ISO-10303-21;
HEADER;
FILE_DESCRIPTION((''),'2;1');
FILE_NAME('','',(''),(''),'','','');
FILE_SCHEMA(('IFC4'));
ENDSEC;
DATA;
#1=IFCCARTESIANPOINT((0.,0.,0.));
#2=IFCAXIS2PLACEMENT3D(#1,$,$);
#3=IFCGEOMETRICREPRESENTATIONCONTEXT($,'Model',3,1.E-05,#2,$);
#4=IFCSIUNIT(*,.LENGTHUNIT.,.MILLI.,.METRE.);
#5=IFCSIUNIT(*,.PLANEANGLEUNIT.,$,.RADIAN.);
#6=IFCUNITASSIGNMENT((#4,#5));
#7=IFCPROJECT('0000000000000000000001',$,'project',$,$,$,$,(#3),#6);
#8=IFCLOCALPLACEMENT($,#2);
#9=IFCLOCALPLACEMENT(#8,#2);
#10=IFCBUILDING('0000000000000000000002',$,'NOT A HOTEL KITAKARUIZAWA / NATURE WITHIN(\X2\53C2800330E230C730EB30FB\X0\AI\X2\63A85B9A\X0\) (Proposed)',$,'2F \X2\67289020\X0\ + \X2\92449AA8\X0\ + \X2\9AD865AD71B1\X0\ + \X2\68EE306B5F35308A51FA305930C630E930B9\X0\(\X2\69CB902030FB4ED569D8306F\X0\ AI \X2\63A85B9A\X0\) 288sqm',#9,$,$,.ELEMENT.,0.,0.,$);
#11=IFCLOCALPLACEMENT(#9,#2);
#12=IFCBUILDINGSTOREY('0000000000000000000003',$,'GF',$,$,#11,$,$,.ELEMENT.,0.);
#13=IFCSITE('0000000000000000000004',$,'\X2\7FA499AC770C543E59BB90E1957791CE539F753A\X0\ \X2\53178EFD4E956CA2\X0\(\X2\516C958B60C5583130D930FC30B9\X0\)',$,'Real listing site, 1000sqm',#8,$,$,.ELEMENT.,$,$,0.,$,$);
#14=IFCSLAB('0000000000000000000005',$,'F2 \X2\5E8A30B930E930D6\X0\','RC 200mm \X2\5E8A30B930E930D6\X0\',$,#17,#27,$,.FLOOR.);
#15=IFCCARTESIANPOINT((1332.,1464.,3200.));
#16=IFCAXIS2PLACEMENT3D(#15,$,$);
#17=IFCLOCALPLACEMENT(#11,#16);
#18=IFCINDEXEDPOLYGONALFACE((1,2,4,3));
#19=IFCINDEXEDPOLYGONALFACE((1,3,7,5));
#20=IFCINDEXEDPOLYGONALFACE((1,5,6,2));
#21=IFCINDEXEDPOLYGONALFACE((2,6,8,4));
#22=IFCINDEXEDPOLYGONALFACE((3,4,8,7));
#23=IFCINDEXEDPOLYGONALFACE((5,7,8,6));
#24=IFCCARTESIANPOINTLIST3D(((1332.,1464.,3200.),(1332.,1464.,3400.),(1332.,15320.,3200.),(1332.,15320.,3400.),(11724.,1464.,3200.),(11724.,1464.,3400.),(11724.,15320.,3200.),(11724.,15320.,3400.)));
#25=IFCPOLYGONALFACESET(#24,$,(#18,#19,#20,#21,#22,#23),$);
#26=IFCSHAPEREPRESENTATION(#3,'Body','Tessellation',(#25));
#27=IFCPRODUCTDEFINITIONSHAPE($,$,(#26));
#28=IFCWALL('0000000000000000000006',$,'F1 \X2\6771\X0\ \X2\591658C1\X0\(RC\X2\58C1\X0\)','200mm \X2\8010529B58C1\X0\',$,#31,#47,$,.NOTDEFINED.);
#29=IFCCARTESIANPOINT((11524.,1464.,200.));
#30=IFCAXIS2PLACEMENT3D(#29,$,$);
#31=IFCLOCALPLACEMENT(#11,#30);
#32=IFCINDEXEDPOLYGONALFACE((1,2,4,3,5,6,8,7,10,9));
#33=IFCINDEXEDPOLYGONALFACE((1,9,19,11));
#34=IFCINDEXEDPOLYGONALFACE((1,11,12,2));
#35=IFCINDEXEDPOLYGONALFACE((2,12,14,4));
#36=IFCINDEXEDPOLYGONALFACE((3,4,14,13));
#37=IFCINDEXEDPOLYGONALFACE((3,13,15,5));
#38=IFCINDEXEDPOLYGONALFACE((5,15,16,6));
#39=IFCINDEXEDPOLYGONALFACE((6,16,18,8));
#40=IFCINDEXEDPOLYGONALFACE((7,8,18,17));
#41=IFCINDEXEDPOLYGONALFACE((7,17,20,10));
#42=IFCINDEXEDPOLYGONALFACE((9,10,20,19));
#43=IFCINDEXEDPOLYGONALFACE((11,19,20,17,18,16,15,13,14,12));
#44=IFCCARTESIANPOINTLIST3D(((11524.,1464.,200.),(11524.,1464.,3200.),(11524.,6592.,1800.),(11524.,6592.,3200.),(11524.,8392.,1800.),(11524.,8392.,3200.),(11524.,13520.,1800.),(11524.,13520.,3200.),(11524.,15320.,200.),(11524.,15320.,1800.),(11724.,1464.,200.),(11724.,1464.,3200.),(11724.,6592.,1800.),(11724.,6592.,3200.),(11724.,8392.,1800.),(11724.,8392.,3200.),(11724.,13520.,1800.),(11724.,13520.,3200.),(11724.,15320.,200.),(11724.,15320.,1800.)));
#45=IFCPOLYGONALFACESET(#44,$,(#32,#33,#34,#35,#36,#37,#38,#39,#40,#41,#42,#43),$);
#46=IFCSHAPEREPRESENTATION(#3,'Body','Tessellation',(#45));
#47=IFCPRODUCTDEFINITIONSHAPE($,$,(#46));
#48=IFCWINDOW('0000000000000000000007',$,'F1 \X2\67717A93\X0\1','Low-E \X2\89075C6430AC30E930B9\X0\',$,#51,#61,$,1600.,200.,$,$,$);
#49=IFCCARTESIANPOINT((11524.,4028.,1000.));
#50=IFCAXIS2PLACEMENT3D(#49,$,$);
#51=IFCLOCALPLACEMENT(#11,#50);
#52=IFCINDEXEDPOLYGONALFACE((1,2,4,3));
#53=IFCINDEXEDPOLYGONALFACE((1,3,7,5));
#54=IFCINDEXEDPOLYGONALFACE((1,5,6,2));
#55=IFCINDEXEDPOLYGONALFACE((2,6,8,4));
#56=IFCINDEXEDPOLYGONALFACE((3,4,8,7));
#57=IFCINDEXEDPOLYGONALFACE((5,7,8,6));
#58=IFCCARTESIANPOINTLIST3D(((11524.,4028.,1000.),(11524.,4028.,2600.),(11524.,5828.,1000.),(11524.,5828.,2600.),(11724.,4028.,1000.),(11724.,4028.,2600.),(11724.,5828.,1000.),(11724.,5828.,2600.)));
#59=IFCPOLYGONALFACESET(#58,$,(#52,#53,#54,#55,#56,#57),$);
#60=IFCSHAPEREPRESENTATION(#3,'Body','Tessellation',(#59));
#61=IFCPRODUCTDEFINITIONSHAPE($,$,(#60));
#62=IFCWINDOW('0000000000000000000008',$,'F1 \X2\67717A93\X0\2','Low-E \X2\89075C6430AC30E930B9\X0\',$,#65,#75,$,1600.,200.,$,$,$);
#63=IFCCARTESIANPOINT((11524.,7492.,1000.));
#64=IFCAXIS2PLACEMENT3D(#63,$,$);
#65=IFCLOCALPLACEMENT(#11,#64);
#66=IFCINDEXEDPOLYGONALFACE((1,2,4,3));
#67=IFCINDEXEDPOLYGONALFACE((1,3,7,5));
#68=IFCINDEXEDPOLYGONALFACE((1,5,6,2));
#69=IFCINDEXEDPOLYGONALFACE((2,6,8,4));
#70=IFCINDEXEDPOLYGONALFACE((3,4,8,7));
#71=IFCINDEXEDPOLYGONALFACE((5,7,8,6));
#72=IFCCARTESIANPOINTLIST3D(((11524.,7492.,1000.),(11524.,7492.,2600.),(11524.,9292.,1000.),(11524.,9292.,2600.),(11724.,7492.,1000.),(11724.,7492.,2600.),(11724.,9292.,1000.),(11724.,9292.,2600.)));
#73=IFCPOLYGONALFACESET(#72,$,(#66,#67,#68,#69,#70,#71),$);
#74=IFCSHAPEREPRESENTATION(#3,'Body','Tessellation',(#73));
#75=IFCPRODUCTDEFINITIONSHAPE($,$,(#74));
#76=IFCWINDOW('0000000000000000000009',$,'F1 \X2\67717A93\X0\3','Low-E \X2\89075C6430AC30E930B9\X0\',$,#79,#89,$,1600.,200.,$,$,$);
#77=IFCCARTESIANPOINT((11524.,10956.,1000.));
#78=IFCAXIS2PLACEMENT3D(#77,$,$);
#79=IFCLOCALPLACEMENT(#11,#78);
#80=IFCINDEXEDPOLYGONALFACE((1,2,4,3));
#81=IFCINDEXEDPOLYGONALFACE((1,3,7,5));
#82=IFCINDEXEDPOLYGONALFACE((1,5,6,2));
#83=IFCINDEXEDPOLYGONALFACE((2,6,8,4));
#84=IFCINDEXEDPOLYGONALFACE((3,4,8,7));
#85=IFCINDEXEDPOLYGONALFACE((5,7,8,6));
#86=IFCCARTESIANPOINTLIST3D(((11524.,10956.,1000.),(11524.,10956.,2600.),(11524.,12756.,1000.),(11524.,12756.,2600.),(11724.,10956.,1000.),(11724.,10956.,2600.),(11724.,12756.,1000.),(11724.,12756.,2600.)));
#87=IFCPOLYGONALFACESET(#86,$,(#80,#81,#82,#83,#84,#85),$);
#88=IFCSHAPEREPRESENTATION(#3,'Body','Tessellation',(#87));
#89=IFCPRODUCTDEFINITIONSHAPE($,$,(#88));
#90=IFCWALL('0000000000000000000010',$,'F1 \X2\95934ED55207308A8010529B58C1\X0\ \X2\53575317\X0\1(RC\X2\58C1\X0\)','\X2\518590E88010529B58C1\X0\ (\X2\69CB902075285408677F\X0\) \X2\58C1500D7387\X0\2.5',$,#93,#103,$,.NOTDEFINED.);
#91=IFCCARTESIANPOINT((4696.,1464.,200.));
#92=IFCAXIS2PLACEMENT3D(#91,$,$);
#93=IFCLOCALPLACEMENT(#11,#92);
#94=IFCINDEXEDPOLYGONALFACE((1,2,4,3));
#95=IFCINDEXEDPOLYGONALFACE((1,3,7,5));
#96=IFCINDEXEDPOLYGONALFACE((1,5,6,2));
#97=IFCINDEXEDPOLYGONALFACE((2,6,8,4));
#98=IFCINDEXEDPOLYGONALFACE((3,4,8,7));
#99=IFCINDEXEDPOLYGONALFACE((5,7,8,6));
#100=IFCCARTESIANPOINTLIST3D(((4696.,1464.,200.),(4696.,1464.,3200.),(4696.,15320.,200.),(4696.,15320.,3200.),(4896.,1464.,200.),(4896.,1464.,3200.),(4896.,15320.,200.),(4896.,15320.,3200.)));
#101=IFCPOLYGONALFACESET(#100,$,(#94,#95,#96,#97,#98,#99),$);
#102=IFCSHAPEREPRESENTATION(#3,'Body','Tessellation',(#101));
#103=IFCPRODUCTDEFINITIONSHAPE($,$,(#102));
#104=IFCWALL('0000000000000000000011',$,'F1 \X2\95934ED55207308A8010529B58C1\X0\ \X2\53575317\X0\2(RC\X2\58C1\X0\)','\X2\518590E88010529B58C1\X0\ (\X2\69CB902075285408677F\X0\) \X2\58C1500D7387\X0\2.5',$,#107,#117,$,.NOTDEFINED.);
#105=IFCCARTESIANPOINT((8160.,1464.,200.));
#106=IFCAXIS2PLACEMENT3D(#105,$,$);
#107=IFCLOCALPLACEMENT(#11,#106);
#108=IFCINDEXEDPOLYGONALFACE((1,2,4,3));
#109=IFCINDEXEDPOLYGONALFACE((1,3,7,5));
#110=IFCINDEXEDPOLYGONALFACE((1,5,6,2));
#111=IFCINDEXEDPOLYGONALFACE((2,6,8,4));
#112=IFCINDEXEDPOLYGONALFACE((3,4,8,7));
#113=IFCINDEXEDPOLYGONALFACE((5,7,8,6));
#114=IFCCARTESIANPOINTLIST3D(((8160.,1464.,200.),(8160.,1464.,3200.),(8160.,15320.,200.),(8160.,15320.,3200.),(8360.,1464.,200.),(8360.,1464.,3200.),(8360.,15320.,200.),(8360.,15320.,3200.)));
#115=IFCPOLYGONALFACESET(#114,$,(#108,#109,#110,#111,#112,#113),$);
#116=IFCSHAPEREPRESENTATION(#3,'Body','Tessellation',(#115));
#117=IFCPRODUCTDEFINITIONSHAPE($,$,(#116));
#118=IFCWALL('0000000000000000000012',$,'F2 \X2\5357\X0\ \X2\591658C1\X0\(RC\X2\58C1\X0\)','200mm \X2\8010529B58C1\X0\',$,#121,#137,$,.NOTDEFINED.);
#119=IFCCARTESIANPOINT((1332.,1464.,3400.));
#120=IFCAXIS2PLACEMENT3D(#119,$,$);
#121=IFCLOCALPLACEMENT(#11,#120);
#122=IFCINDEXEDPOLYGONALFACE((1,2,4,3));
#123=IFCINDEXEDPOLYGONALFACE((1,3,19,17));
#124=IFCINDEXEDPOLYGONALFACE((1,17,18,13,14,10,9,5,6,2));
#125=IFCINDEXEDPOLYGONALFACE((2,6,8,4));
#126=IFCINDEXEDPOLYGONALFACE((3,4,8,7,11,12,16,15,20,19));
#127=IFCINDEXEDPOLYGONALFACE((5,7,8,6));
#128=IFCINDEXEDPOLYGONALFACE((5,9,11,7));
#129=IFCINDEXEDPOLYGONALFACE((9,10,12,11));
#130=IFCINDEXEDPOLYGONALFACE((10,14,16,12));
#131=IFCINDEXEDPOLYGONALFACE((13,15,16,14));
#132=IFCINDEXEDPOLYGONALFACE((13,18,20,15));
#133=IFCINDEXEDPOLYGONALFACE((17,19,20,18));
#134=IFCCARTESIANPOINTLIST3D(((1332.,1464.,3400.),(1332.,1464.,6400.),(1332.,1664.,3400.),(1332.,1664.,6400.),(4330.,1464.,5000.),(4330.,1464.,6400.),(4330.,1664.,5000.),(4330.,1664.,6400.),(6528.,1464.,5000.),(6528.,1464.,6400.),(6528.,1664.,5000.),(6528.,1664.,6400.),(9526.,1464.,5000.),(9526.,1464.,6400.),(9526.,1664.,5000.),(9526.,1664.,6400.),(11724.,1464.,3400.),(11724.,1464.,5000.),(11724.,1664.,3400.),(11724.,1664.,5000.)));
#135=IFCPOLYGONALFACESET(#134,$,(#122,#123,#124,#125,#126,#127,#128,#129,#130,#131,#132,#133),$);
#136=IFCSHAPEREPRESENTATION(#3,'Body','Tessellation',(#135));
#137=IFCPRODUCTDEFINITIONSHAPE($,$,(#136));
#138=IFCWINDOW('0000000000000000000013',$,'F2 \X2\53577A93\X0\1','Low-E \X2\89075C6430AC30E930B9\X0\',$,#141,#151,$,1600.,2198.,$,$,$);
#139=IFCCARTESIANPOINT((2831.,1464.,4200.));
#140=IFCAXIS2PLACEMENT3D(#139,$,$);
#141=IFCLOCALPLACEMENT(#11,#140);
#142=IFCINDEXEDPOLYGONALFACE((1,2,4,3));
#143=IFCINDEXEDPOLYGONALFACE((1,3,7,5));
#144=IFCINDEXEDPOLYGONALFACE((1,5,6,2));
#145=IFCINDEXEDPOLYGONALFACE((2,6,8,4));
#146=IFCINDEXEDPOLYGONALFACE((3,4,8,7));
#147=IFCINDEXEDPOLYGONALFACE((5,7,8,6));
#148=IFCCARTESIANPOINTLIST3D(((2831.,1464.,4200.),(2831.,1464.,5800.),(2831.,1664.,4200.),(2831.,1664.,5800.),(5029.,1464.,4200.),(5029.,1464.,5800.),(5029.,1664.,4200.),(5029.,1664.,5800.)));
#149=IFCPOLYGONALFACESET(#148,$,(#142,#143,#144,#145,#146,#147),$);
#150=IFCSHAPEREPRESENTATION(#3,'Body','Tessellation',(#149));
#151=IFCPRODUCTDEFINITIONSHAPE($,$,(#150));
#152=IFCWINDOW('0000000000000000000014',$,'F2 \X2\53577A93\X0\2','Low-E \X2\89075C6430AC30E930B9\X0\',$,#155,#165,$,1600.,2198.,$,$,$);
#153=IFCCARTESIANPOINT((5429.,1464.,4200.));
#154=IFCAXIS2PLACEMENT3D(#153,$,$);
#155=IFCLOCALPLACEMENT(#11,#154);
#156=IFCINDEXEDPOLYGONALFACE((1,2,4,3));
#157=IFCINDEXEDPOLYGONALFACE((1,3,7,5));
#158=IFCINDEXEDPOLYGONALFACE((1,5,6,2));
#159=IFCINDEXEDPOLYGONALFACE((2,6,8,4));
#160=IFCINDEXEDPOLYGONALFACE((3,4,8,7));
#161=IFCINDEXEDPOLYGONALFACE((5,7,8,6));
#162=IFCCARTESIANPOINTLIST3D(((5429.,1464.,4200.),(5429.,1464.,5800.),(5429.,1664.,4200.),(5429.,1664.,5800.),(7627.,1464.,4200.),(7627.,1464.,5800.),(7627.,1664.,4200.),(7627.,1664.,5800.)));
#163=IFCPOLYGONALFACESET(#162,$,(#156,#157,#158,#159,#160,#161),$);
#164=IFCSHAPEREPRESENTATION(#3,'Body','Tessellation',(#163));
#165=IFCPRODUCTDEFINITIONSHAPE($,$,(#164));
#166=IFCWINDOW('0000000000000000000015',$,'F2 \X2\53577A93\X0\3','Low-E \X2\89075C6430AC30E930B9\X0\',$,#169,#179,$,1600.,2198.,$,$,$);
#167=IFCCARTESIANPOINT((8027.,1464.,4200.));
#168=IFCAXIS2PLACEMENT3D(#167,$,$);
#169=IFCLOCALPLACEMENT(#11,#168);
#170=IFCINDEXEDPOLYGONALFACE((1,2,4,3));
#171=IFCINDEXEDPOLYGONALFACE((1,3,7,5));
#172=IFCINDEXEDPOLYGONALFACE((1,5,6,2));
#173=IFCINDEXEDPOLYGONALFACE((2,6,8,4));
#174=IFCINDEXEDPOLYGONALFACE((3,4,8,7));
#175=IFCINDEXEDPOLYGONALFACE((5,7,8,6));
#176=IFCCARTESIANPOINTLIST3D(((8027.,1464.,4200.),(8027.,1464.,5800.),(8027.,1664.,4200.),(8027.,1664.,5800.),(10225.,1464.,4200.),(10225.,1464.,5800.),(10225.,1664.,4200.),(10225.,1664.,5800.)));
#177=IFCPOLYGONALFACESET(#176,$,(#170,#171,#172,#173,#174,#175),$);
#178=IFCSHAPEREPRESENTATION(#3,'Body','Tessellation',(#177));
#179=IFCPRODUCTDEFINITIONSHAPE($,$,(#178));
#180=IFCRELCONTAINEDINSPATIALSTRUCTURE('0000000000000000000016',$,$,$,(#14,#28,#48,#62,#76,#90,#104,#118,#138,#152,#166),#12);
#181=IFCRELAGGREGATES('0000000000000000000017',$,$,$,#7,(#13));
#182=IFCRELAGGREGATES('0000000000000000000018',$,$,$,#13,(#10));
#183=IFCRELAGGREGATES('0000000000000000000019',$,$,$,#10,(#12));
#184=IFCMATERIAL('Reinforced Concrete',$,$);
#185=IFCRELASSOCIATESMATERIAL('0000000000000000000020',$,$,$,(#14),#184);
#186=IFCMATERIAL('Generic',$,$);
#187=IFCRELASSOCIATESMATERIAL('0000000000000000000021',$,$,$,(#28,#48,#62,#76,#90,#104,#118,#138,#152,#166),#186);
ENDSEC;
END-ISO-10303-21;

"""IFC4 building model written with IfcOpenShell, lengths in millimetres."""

from ifc_helpers import new_model, si_unit, frame, frame_2d, origin, place, context, project, spatial, rectangle, extrude, material, element, fill, save


model = new_model("IFC4")

# Units and contexts
model_context = context("Model", 3, precision=1e-05, world=origin())
ifc_project = project(units=[si_unit("LENGTHUNIT", "METRE", prefix="MILLI"), si_unit("PLANEANGLEUNIT", "RADIAN")], contexts=[model_context])

# Site, building, storey
site_placement = place(None, origin())
site = spatial("IfcSite", under=ifc_project, at=site_placement, Name="群馬県吾妻郡長野原町 北軽井沢(公開情報ベース)", ObjectType="Real listing site, 1000sqm", CompositionType="ELEMENT", RefElevation=0.0)
building_placement = place(site_placement, origin())
building = spatial("IfcBuilding", under=site, at=building_placement, Name="NOT A HOTEL KITAKARUIZAWA / NATURE WITHIN(参考モデル・AI推定) (Proposed)", ObjectType="2F 木造 + 鉄骨 + 高断熱 + 森に張り出すテラス(構造・仕様は AI 推定) 288sqm", CompositionType="ELEMENT", ElevationOfRefHeight=0.0, ElevationOfTerrain=0.0)
storey_placement = place(building_placement, origin())
storey = spatial("IfcBuildingStorey", under=building, at=storey_placement, Name="GF", CompositionType="ELEMENT", Elevation=0.0)

# Slab
ifc_material_1 = material(Name="Reinforced Concrete")
slab_placement = place(storey_placement, frame((1332.0, 1464.0, 3200.0)))
element("IfcSlab", 1, at=slab_placement, inside=storey, material=ifc_material_1, Name="F2 床スラブ", Description="RC 200mm 床スラブ", PredefinedType="FLOOR", context=model_context, shape_type="SweptSolid", body=[
    extrude(rectangle(XDim=10392.0, YDim=13856.0, at=frame_2d((5196.0, 6928.0))), frame((1332.0, 1464.0, 3200.0)), (0.0, 0.0, 1.0), 200.0),
])

# Wall, openings, windows
ifc_material_2 = material(Name="Generic")
wall_1_placement = place(storey_placement, frame((11524.0, 1464.0, 200.0)))
wall_1 = element("IfcWall", 2, at=wall_1_placement, inside=storey, material=ifc_material_2, Name="F1 東 外壁(RC壁)", Description="200mm 耐力壁", PredefinedType="NOTDEFINED", context=model_context, shape_type="SweptSolid", body=[
    extrude(rectangle(XDim=200.0, YDim=13856.0, at=frame_2d((100.0, 6928.0))), frame((11524.0, 1464.0, 200.0)), (0.0, 0.0, 1.0), 3000.0),
])
opening_1_placement = place(storey_placement, frame((11524.0, 4028.0, 1000.0)))
opening_1 = element("IfcOpeningElement", 3, at=opening_1_placement, cuts=wall_1, PredefinedType="NOTDEFINED", context=model_context, shape_type="SweptSolid", body=[
    extrude(rectangle(XDim=200.0, YDim=1800.0, at=frame_2d((100.0, 900.0))), frame((11524.0, 4028.0, 1000.0)), (0.0, 0.0, 1.0), 1600.0),
])
opening_2_placement = place(storey_placement, frame((11524.0, 7492.0, 1000.0)))
opening_2 = element("IfcOpeningElement", 4, at=opening_2_placement, cuts=wall_1, PredefinedType="NOTDEFINED", context=model_context, shape_type="SweptSolid", body=[
    extrude(rectangle(XDim=200.0, YDim=1800.0, at=frame_2d((100.0, 900.0))), frame((11524.0, 7492.0, 1000.0)), (0.0, 0.0, 1.0), 1600.0),
])
opening_3_placement = place(storey_placement, frame((11524.0, 10956.0, 1000.0)))
opening_3 = element("IfcOpeningElement", 5, at=opening_3_placement, cuts=wall_1, PredefinedType="NOTDEFINED", context=model_context, shape_type="SweptSolid", body=[
    extrude(rectangle(XDim=200.0, YDim=1800.0, at=frame_2d((100.0, 900.0))), frame((11524.0, 10956.0, 1000.0)), (0.0, 0.0, 1.0), 1600.0),
])
window_1_placement = place(storey_placement, frame((11524.0, 4028.0, 1000.0)))
window_1 = element("IfcWindow", 6, at=window_1_placement, inside=storey, material=ifc_material_2, Name="F1 東窓1", Description="Low-E 複層ガラス", OverallHeight=1600.0, OverallWidth=200.0, context=model_context, shape_type="SweptSolid", body=[
    extrude(rectangle(XDim=200.0, YDim=1800.0, at=frame_2d((100.0, 900.0))), frame((11524.0, 4028.0, 1000.0)), (0.0, 0.0, 1.0), 1600.0),
])
fill(opening_1, window_1)
window_2_placement = place(storey_placement, frame((11524.0, 7492.0, 1000.0)))
window_2 = element("IfcWindow", 7, at=window_2_placement, inside=storey, material=ifc_material_2, Name="F1 東窓2", Description="Low-E 複層ガラス", OverallHeight=1600.0, OverallWidth=200.0, context=model_context, shape_type="SweptSolid", body=[
    extrude(rectangle(XDim=200.0, YDim=1800.0, at=frame_2d((100.0, 900.0))), frame((11524.0, 7492.0, 1000.0)), (0.0, 0.0, 1.0), 1600.0),
])
fill(opening_2, window_2)
window_3_placement = place(storey_placement, frame((11524.0, 10956.0, 1000.0)))
window_3 = element("IfcWindow", 8, at=window_3_placement, inside=storey, material=ifc_material_2, Name="F1 東窓3", Description="Low-E 複層ガラス", OverallHeight=1600.0, OverallWidth=200.0, context=model_context, shape_type="SweptSolid", body=[
    extrude(rectangle(XDim=200.0, YDim=1800.0, at=frame_2d((100.0, 900.0))), frame((11524.0, 10956.0, 1000.0)), (0.0, 0.0, 1.0), 1600.0),
])
fill(opening_3, window_3)

# Walls
wall_2_placement = place(storey_placement, frame((4696.0, 1464.0, 200.0)))
element("IfcWall", 9, at=wall_2_placement, inside=storey, material=ifc_material_2, Name="F1 間仕切り耐力壁 南北1(RC壁)", Description="内部耐力壁 (構造用合板) 壁倍率2.5", PredefinedType="NOTDEFINED", context=model_context, shape_type="SweptSolid", body=[
    extrude(rectangle(XDim=200.0, YDim=13856.0, at=frame_2d((100.0, 6928.0))), frame((4696.0, 1464.0, 200.0)), (0.0, 0.0, 1.0), 3000.0),
])
wall_3_placement = place(storey_placement, frame((8160.0, 1464.0, 200.0)))
element("IfcWall", 10, at=wall_3_placement, inside=storey, material=ifc_material_2, Name="F1 間仕切り耐力壁 南北2(RC壁)", Description="内部耐力壁 (構造用合板) 壁倍率2.5", PredefinedType="NOTDEFINED", context=model_context, shape_type="SweptSolid", body=[
    extrude(rectangle(XDim=200.0, YDim=13856.0, at=frame_2d((100.0, 6928.0))), frame((8160.0, 1464.0, 200.0)), (0.0, 0.0, 1.0), 3000.0),
])

# Wall, openings, windows
wall_4_placement = place(storey_placement, frame((1332.0, 1464.0, 3400.0)))
wall_4 = element("IfcWall", 11, at=wall_4_placement, inside=storey, material=ifc_material_2, Name="F2 南 外壁(RC壁)", Description="200mm 耐力壁", PredefinedType="NOTDEFINED", context=model_context, shape_type="SweptSolid", body=[
    extrude(rectangle(XDim=10392.0, YDim=200.0, at=frame_2d((5196.0, 100.0))), frame((1332.0, 1464.0, 3400.0)), (0.0, 0.0, 1.0), 3000.0),
])
opening_4_placement = place(storey_placement, frame((2831.0, 1464.0, 4200.0)))
opening_4 = element("IfcOpeningElement", 12, at=opening_4_placement, cuts=wall_4, PredefinedType="NOTDEFINED", context=model_context, shape_type="SweptSolid", body=[
    extrude(rectangle(XDim=2198.0, YDim=200.0, at=frame_2d((1099.0, 100.0))), frame((2831.0, 1464.0, 4200.0)), (0.0, 0.0, 1.0), 1600.0),
])
opening_5_placement = place(storey_placement, frame((5429.0, 1464.0, 4200.0)))
opening_5 = element("IfcOpeningElement", 13, at=opening_5_placement, cuts=wall_4, PredefinedType="NOTDEFINED", context=model_context, shape_type="SweptSolid", body=[
    extrude(rectangle(XDim=2198.0, YDim=200.0, at=frame_2d((1099.0, 100.0))), frame((5429.0, 1464.0, 4200.0)), (0.0, 0.0, 1.0), 1600.0),
])
opening_6_placement = place(storey_placement, frame((8027.0, 1464.0, 4200.0)))
opening_6 = element("IfcOpeningElement", 14, at=opening_6_placement, cuts=wall_4, PredefinedType="NOTDEFINED", context=model_context, shape_type="SweptSolid", body=[
    extrude(rectangle(XDim=2198.0, YDim=200.0, at=frame_2d((1099.0, 100.0))), frame((8027.0, 1464.0, 4200.0)), (0.0, 0.0, 1.0), 1600.0),
])
window_4_placement = place(storey_placement, frame((2831.0, 1464.0, 4200.0)))
window_4 = element("IfcWindow", 15, at=window_4_placement, inside=storey, material=ifc_material_2, Name="F2 南窓1", Description="Low-E 複層ガラス", OverallHeight=1600.0, OverallWidth=2198.0, context=model_context, shape_type="SweptSolid", body=[
    extrude(rectangle(XDim=2198.0, YDim=200.0, at=frame_2d((1099.0, 100.0))), frame((2831.0, 1464.0, 4200.0)), (0.0, 0.0, 1.0), 1600.0),
])
fill(opening_4, window_4)
window_5_placement = place(storey_placement, frame((5429.0, 1464.0, 4200.0)))
window_5 = element("IfcWindow", 16, at=window_5_placement, inside=storey, material=ifc_material_2, Name="F2 南窓2", Description="Low-E 複層ガラス", OverallHeight=1600.0, OverallWidth=2198.0, context=model_context, shape_type="SweptSolid", body=[
    extrude(rectangle(XDim=2198.0, YDim=200.0, at=frame_2d((1099.0, 100.0))), frame((5429.0, 1464.0, 4200.0)), (0.0, 0.0, 1.0), 1600.0),
])
fill(opening_5, window_5)
window_6_placement = place(storey_placement, frame((8027.0, 1464.0, 4200.0)))
window_6 = element("IfcWindow", 17, at=window_6_placement, inside=storey, material=ifc_material_2, Name="F2 南窓3", Description="Low-E 複層ガラス", OverallHeight=1600.0, OverallWidth=2198.0, context=model_context, shape_type="SweptSolid", body=[
    extrude(rectangle(XDim=2198.0, YDim=200.0, at=frame_2d((1099.0, 100.0))), frame((8027.0, 1464.0, 4200.0)), (0.0, 0.0, 1.0), 1600.0),
])
fill(opening_6, window_6)

save(model, "model.ifc")
